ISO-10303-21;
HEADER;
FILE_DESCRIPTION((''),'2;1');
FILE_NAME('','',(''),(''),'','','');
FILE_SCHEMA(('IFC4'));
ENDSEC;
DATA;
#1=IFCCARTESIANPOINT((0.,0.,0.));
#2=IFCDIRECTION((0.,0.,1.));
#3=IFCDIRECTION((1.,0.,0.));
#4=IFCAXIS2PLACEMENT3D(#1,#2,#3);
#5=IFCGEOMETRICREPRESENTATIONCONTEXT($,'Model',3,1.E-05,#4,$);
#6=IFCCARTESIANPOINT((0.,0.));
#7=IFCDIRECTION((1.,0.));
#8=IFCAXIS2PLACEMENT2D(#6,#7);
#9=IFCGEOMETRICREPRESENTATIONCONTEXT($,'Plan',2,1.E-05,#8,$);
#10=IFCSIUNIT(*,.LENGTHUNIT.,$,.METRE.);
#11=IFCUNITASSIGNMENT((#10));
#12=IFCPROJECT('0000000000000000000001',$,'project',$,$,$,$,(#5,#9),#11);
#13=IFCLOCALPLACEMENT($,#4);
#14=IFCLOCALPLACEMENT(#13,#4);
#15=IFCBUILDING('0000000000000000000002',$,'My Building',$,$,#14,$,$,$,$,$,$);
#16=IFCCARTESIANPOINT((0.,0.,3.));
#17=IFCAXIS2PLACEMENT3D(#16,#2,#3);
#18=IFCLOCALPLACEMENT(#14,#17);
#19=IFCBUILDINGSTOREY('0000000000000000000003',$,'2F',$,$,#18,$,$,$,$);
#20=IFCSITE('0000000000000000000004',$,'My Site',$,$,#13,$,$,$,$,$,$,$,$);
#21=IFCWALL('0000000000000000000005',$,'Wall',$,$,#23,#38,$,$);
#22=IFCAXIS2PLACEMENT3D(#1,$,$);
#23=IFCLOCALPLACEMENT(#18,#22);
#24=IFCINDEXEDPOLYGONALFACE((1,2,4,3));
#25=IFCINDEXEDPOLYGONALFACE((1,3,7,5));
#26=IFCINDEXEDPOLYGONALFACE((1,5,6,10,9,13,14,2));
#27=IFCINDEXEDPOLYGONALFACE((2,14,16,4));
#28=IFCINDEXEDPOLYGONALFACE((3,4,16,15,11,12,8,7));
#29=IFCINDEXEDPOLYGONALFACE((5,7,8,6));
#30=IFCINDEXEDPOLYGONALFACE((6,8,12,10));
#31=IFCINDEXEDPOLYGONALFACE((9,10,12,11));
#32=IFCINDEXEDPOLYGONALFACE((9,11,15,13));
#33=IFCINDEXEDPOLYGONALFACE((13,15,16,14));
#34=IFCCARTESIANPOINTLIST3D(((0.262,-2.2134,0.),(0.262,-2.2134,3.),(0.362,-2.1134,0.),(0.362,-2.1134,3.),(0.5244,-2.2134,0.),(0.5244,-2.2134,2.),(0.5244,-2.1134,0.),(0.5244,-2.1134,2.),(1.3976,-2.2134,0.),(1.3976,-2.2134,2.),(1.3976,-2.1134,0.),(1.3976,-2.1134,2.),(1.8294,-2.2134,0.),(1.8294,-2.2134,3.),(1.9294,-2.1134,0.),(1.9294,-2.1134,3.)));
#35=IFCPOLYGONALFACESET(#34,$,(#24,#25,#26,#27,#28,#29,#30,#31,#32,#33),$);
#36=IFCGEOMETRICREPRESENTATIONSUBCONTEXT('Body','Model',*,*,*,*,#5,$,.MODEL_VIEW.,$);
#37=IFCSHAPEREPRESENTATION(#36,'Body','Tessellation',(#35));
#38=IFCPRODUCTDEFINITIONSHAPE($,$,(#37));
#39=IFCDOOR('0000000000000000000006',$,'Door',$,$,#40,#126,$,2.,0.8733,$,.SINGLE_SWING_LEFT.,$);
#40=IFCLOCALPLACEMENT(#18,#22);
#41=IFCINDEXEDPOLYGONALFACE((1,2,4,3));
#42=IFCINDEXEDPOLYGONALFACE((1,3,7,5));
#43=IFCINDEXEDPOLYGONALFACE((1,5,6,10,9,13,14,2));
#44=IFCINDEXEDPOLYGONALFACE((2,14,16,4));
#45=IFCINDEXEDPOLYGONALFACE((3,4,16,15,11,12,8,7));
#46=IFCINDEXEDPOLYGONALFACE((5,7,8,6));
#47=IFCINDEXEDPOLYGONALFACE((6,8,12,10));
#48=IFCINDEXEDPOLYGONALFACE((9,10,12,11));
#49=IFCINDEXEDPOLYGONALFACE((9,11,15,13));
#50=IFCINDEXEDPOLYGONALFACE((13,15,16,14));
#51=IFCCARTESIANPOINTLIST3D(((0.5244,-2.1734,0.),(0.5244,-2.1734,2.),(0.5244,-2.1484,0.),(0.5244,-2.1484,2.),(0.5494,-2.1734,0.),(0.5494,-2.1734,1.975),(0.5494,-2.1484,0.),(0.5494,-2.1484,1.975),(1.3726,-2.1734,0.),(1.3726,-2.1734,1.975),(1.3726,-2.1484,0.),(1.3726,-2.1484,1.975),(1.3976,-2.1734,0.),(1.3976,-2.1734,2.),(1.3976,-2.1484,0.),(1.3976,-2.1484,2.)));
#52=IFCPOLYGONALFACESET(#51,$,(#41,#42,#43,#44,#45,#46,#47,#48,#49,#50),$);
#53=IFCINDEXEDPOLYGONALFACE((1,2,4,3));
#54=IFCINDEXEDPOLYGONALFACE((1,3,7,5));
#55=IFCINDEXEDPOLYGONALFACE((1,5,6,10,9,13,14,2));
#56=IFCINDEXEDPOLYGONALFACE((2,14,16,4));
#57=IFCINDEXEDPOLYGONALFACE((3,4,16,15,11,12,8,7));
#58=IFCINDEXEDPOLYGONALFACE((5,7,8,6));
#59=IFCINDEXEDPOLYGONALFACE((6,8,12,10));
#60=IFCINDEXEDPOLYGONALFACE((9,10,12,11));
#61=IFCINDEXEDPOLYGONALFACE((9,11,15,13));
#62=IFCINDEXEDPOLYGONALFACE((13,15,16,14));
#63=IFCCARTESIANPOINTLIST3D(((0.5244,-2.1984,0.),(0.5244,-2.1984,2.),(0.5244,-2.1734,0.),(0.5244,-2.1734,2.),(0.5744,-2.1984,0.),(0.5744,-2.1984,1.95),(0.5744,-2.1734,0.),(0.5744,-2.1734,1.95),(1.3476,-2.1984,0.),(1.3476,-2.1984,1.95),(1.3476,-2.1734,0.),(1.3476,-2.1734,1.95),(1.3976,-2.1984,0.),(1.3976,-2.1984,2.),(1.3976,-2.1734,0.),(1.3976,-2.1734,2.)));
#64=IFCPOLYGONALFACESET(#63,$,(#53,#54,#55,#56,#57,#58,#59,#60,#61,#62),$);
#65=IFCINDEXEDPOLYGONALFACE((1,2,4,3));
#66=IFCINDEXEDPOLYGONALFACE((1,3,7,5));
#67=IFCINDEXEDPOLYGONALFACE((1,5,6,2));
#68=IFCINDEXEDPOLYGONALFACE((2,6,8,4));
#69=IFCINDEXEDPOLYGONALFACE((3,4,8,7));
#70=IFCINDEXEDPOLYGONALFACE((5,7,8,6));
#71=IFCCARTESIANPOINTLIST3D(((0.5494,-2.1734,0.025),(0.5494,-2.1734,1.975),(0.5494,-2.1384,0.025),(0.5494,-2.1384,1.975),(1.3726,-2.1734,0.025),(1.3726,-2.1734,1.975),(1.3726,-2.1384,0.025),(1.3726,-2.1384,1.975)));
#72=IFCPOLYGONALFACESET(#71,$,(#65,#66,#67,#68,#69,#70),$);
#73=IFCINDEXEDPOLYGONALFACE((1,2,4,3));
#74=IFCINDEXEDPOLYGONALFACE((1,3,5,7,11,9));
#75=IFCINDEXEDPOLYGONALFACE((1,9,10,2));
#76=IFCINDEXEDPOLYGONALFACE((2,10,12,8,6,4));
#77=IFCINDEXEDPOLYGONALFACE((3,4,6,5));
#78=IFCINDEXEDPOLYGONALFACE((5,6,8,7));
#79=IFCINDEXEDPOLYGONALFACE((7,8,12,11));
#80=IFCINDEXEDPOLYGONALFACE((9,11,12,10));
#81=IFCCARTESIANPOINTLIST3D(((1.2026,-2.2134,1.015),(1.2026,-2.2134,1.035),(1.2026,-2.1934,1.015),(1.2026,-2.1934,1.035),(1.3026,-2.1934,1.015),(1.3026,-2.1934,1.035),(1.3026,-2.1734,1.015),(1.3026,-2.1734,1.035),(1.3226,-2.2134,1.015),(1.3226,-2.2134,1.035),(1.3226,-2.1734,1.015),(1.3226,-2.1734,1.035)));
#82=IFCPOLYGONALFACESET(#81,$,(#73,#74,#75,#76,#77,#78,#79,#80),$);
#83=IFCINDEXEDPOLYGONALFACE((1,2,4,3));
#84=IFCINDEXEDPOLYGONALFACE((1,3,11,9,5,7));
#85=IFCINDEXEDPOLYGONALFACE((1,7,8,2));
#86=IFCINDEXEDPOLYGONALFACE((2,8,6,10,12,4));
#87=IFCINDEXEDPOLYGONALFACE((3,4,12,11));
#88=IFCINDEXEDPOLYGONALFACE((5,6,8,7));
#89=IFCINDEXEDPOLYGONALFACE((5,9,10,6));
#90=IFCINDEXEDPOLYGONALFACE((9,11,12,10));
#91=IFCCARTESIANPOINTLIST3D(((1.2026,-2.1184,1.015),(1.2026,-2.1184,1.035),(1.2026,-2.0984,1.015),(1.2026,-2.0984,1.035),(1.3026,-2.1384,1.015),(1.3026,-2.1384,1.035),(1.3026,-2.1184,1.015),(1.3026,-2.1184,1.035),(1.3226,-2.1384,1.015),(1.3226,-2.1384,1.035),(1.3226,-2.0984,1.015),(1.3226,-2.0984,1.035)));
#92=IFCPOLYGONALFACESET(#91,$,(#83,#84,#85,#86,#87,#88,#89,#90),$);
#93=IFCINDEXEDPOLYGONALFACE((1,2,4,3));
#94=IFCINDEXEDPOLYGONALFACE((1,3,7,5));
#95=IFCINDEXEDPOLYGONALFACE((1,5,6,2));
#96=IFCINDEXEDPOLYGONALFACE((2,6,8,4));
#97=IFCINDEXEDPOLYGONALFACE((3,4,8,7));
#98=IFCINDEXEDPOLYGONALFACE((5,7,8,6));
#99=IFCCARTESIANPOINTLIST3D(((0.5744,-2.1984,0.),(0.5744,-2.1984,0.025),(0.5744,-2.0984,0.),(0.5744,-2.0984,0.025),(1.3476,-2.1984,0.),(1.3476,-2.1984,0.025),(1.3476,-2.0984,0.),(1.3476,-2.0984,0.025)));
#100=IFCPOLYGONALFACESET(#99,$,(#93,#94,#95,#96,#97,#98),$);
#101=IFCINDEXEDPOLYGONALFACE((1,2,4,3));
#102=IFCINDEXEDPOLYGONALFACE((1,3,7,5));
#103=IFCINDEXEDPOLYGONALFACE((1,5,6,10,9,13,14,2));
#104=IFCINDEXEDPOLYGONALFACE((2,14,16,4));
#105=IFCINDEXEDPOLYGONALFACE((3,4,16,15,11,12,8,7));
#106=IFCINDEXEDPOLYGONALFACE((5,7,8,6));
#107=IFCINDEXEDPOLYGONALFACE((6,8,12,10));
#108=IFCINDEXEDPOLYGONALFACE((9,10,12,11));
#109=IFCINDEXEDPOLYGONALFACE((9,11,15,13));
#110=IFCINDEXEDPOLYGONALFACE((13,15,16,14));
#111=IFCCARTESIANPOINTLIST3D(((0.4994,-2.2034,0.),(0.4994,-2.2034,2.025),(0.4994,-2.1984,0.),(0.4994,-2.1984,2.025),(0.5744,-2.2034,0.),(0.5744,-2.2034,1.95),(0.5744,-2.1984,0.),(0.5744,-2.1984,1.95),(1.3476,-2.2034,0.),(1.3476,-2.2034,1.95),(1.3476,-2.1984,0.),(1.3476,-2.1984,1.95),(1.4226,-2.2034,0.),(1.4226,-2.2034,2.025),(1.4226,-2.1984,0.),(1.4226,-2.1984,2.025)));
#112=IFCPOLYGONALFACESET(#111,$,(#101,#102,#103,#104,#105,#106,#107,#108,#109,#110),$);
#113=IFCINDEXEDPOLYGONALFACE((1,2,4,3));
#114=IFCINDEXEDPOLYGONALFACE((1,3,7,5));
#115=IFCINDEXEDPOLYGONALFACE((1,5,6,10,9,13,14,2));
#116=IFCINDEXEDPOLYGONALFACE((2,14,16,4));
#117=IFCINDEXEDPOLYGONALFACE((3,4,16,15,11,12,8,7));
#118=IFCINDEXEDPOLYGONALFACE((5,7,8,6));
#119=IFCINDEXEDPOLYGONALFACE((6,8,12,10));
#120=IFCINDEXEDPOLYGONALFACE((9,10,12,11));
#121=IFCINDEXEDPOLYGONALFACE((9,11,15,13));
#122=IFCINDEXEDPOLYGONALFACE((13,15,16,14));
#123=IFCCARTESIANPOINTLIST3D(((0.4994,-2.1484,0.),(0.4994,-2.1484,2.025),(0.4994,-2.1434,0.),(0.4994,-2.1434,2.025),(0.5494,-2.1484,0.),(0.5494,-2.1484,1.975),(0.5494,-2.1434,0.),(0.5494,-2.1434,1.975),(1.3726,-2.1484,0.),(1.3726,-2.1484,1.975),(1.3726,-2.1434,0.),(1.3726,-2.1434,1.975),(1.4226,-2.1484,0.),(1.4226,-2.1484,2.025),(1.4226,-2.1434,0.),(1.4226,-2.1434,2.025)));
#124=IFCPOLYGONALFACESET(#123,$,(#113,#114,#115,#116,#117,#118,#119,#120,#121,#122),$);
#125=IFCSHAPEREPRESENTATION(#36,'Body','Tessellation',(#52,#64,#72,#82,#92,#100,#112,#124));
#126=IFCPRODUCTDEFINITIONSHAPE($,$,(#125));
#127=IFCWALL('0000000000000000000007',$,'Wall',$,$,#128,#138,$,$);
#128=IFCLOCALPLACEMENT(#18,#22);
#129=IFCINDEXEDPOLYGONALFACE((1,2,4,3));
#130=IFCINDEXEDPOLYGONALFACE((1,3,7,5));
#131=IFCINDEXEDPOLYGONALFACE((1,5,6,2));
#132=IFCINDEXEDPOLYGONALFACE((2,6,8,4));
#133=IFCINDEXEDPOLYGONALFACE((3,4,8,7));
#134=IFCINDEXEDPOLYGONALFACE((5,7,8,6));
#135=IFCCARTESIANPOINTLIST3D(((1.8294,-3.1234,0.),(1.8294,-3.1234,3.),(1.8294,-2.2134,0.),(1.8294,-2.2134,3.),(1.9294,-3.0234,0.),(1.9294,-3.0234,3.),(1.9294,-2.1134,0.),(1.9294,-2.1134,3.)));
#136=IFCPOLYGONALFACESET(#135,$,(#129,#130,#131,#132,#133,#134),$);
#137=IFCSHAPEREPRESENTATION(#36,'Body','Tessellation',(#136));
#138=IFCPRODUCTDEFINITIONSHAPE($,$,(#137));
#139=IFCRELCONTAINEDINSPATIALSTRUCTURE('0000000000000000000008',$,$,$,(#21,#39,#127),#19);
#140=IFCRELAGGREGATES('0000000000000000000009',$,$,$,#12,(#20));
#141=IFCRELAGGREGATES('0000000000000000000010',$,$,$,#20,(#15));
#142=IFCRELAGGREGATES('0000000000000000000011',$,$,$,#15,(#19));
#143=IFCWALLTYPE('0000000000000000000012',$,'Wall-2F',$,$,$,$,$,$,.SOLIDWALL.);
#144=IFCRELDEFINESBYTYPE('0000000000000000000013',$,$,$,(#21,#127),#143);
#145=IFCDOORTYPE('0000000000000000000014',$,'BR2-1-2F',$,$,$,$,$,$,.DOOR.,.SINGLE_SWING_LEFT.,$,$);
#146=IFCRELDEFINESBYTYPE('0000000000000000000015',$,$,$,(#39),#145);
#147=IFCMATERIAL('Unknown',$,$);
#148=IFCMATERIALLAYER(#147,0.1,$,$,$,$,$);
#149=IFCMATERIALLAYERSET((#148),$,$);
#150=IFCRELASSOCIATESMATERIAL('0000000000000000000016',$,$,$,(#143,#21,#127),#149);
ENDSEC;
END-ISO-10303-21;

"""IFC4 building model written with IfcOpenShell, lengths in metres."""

from ifc_helpers import new_model, entity, si_unit, frame, origin_with_axes, origin_2d_with_axis, place, context, subcontext, project, spatial, line, indexed_curve, outline, extrude, shape, source, transform, mapped, material, layer, layer_set, layer_usage, type_object, type_shapes, element, fill, save


model = new_model("IFC4")

# Units and contexts
model_context = context("Model", 3, precision=1e-05, world=origin_with_axes())
plan_context = context("Plan", 2, precision=1e-05, world=origin_2d_with_axis())
body_context_1 = subcontext(model_context, "Body", "Model", "MODEL_VIEW")
body_context_2 = subcontext(plan_context, "Body", "Plan", "PLAN_VIEW")
ifc_project = project(units=[si_unit("LENGTHUNIT", "METRE")], contexts=[model_context, plan_context])

# Site, building, storey
site_placement = place(None, origin_with_axes())
site = spatial("IfcSite", under=ifc_project, at=site_placement, Name="My Site")
building_placement = place(site_placement, origin_with_axes())
building = spatial("IfcBuilding", under=site, at=building_placement, Name="My Building")
storey_placement = place(building_placement, frame((0.0, 0.0, 3.0), z_axis=(0.0, 0.0, 1.0), x_axis=(1.0, 0.0, 0.0)))
storey = spatial("IfcBuildingStorey", under=building, at=storey_placement, Name="2F")

# Shared definitions
ifc_material = material(Name="Unknown")

# Shared definitions
ifc_layer_1 = layer(ifc_material, 0.1)
ifc_layer_set_1 = layer_set([ifc_layer_1])
wall_type_1 = type_object("IfcWallType", Name="Wall-2F", PredefinedType="SOLIDWALL", material=ifc_layer_set_1)

# Wall, opening, door
ifc_layer_usage_1 = layer_usage(ifc_layer_set_1, "AXIS2", "POSITIVE", 0.0)
wall_1_placement = place(storey_placement, frame((0.262, -2.2134, 0.0), z_axis=(0.0, 0.0, 1.0), x_axis=(1.0, 0.0, 0.0)))
wall_1 = element("IfcWall", 1, at=wall_1_placement, inside=storey, type_object=wall_type_1, material=ifc_layer_usage_1, Name="Wall", context=body_context_1, shape_type="SweptSolid", body=[
    extrude(outline(indexed_curve([(0.0, 0.0), (0.1, 0.1), (1.6674, 0.1), (1.5674, 0.0)], segments=[line(1, 2, 3, 4, 1)])), origin_with_axes(), (0.0, 0.0, 1.0), 3.0),
])
shared_shape_1 = source(origin_with_axes(), body_context_1, "Body", "SweptSolid", [
    extrude(outline(indexed_curve([(0.0, 0.0), (0.8733, 0.0), (0.8733, 2.0), (0.0, 2.0)], segments=[line(1, 2, 3, 4, 1)])), frame((0.0, -0.6, 0.0), z_axis=(0.0, -1.0, 0.0), x_axis=(1.0, 0.0, 0.0)), (0.0, 0.0, -1.0), 1.2),
])
opening_1_placement = place(wall_1_placement, frame((0.2623, 0.015, 0.0), z_axis=(0.0, 0.0, 1.0), x_axis=(1.0, 0.0, 0.0)))
opening_1 = element("IfcOpeningElement", 2, at=opening_1_placement, cuts=wall_1, PredefinedType="OPENING", context=body_context_1, shape_type="MappedRepresentation", body=[
    mapped(shared_shape_1, transform((0.0, 0.0, 0.0), x_axis=(1.0, 0.0, 0.0), y_axis=(0.0, 1.0, 0.0), z_axis=(0.0, 0.0, 1.0), scale=1.0)),
])
door_type_1 = type_object("IfcDoorType", Name="BR2-1-2F", OperationType="SINGLE_SWING_LEFT", PredefinedType="DOOR")
shared_shape_2 = source(origin_with_axes(), body_context_1, "Body", "SweptSolid", [
    extrude(outline(indexed_curve([(0.0, 0.0), (0.0, 2.0), (0.8733, 2.0), (0.8733, 0.0), (0.8483, 0.0), (0.8483, 1.975), (0.025, 1.975), (0.025, 0.0)], segments=[line(1, 2, 3, 4, 5, 6, 7, 8, 1)])), frame((0.0, 0.025, 0.0), z_axis=(0.0, -1.0, 0.0), x_axis=(1.0, 0.0, 0.0)), (0.0, 0.0, -1.0), 0.025),
    extrude(outline(indexed_curve([(0.0, 0.0), (0.0, 2.0), (0.8733, 2.0), (0.8733, 0.0), (0.8233, 0.0), (0.8233, 1.95), (0.05, 1.95), (0.05, 0.0)], segments=[line(1, 2, 3, 4, 5, 6, 7, 8, 1)])), frame((0.0, 0.0, 0.0), z_axis=(0.0, -1.0, 0.0), x_axis=(1.0, 0.0, 0.0)), (0.0, 0.0, -1.0), 0.025),
    extrude(outline(indexed_curve([(0.0, 0.0), (0.8233, 0.0), (0.8233, 0.035), (0.0, 0.035)], segments=[line(1, 2, 3, 4, 1)])), frame((0.025, 0.025, 0.025), z_axis=(0.0, 0.0, 1.0), x_axis=(1.0, 0.0, 0.0)), (0.0, 0.0, 1.0), 1.95),
    extrude(outline(indexed_curve([(0.0, 0.0), (0.0, -0.04), (-0.12, -0.04), (-0.12, -0.02), (-0.02, -0.02), (-0.02, 0.0)], segments=[line(1, 2, 3, 4, 5, 6, 1)])), frame((0.7983, 0.025, 1.015), z_axis=(0.0, 0.0, 1.0), x_axis=(1.0, 0.0, 0.0)), (0.0, 0.0, 1.0), 0.02),
    extrude(outline(indexed_curve([(0.0, 0.0), (0.0, 0.04), (-0.12, 0.04), (-0.12, 0.02), (-0.02, 0.02), (-0.02, 0.0)], segments=[line(1, 2, 3, 4, 5, 6, 1)])), frame((0.7983, 0.06, 1.015), z_axis=(0.0, 0.0, 1.0), x_axis=(1.0, 0.0, 0.0)), (0.0, 0.0, 1.0), 0.02),
    extrude(outline(indexed_curve([(0.0, 0.0), (0.7733, 0.0), (0.7733, 0.1), (0.0, 0.1)], segments=[line(1, 2, 3, 4, 1)])), frame((0.05, 0.0, 0.0), z_axis=(0.0, 0.0, 1.0), x_axis=(1.0, 0.0, 0.0)), (0.0, 0.0, 1.0), 0.025),
    extrude(outline(indexed_curve([(0.0, 0.0), (0.0, 2.025), (0.9233, 2.025), (0.9233, 0.0), (0.8483, 0.0), (0.8483, 1.95), (0.075, 1.95), (0.075, 0.0)], segments=[line(1, 2, 3, 4, 5, 6, 7, 8, 1)])), frame((-0.025, -0.005, 0.0), z_axis=(0.0, -1.0, 0.0), x_axis=(1.0, 0.0, 0.0)), (0.0, 0.0, -1.0), 0.005),
    extrude(outline(indexed_curve([(0.0, 0.0), (0.0, 2.025), (0.9233, 2.025), (0.9233, 0.0), (0.8733, 0.0), (0.8733, 1.975), (0.05, 1.975), (0.05, 0.0)], segments=[line(1, 2, 3, 4, 5, 6, 7, 8, 1)])), frame((-0.025, 0.05, 0.0), z_axis=(0.0, -1.0, 0.0), x_axis=(1.0, 0.0, 0.0)), (0.0, 0.0, -1.0), 0.005),
])
shared_shape_3 = source(origin_with_axes(), body_context_2, "Body", "Curve2D", [
    entity("IfcIndexedPolyCurve", entity("IfcCartesianPointList2D", [[0.0, 0.0], [0.0, 0.05], [0.025, 0.05], [0.025, 0.025], [0.05, 0.025], [0.05, 0.0]]), [entity("IfcLineIndex", [1, 2, 3, 4, 5, 6, 1])]),
    entity("IfcIndexedPolyCurve", entity("IfcCartesianPointList2D", [[0.8733, 0.0], [0.8733, 0.05], [0.8483, 0.05], [0.8483, 0.025], [0.8233, 0.025], [0.8233, 0.0]]), [entity("IfcLineIndex", [1, 2, 3, 4, 5, 6, 1])]),
    entity("IfcTrimmedCurve", entity("IfcEllipse", entity("IfcAxis2Placement2D", entity("IfcCartesianPoint", [0.06, 0.05]), entity("IfcDirection", [1.0, 0.0])), 0.7883, 0.8233), [entity("IfcCartesianPoint", [0.8483, 0.05])], [entity("IfcCartesianPoint", [0.06, 0.8733])], True, "CARTESIAN"),
    entity("IfcIndexedPolyCurve", entity("IfcCartesianPointList2D", [[0.025, 0.05], [0.06, 0.05], [0.06, 0.8733], [0.025, 0.8733]]), [entity("IfcLineIndex", [1, 2, 3, 4, 1])]),
])
type_shapes(door_type_1, [shared_shape_2, shared_shape_3])
door_1_placement = place(opening_1_placement, origin_with_axes())
door_1 = element("IfcDoor", 3, at=door_1_placement, inside=storey, type_object=door_type_1, Name="Door", OperationType="SINGLE_SWING_LEFT", OverallHeight=2.0, OverallWidth=0.8733, shapes=[
    shape(body_context_1, "Body", "MappedRepresentation", [mapped(shared_shape_2, transform((0.0, 0.0, 0.0), x_axis=(1.0, 0.0, 0.0), y_axis=(0.0, 1.0, 0.0), z_axis=(0.0, 0.0, 1.0), scale=1.0))]),
    shape(body_context_2, "Body", "MappedRepresentation", [mapped(shared_shape_3, transform((0.0, 0.0, 0.0), x_axis=(1.0, 0.0, 0.0), y_axis=(0.0, 1.0, 0.0), z_axis=(0.0, 0.0, 1.0), scale=1.0))]),
])
fill(opening_1, door_1)

# Wall
ifc_layer_usage_2 = layer_usage(ifc_layer_set_1, "AXIS2", "POSITIVE", 0.0)
wall_2_placement = place(storey_placement, frame((1.8294, -2.2134, 0.0), z_axis=(0.0, 0.0, 1.0), x_axis=(0.0, -1.0, 0.0)))
element("IfcWall", 4, at=wall_2_placement, inside=storey, type_object=wall_type_1, material=ifc_layer_usage_2, Name="Wall", context=body_context_1, shape_type="SweptSolid", body=[
    extrude(outline(indexed_curve([(0.0, 0.0), (-0.1, 0.1), (0.81, 0.1), (0.91, 0.0)], segments=[line(1, 2, 3, 4, 1)])), origin_with_axes(), (0.0, 0.0, 1.0), 3.0),
])

save(model, "model.ifc")
